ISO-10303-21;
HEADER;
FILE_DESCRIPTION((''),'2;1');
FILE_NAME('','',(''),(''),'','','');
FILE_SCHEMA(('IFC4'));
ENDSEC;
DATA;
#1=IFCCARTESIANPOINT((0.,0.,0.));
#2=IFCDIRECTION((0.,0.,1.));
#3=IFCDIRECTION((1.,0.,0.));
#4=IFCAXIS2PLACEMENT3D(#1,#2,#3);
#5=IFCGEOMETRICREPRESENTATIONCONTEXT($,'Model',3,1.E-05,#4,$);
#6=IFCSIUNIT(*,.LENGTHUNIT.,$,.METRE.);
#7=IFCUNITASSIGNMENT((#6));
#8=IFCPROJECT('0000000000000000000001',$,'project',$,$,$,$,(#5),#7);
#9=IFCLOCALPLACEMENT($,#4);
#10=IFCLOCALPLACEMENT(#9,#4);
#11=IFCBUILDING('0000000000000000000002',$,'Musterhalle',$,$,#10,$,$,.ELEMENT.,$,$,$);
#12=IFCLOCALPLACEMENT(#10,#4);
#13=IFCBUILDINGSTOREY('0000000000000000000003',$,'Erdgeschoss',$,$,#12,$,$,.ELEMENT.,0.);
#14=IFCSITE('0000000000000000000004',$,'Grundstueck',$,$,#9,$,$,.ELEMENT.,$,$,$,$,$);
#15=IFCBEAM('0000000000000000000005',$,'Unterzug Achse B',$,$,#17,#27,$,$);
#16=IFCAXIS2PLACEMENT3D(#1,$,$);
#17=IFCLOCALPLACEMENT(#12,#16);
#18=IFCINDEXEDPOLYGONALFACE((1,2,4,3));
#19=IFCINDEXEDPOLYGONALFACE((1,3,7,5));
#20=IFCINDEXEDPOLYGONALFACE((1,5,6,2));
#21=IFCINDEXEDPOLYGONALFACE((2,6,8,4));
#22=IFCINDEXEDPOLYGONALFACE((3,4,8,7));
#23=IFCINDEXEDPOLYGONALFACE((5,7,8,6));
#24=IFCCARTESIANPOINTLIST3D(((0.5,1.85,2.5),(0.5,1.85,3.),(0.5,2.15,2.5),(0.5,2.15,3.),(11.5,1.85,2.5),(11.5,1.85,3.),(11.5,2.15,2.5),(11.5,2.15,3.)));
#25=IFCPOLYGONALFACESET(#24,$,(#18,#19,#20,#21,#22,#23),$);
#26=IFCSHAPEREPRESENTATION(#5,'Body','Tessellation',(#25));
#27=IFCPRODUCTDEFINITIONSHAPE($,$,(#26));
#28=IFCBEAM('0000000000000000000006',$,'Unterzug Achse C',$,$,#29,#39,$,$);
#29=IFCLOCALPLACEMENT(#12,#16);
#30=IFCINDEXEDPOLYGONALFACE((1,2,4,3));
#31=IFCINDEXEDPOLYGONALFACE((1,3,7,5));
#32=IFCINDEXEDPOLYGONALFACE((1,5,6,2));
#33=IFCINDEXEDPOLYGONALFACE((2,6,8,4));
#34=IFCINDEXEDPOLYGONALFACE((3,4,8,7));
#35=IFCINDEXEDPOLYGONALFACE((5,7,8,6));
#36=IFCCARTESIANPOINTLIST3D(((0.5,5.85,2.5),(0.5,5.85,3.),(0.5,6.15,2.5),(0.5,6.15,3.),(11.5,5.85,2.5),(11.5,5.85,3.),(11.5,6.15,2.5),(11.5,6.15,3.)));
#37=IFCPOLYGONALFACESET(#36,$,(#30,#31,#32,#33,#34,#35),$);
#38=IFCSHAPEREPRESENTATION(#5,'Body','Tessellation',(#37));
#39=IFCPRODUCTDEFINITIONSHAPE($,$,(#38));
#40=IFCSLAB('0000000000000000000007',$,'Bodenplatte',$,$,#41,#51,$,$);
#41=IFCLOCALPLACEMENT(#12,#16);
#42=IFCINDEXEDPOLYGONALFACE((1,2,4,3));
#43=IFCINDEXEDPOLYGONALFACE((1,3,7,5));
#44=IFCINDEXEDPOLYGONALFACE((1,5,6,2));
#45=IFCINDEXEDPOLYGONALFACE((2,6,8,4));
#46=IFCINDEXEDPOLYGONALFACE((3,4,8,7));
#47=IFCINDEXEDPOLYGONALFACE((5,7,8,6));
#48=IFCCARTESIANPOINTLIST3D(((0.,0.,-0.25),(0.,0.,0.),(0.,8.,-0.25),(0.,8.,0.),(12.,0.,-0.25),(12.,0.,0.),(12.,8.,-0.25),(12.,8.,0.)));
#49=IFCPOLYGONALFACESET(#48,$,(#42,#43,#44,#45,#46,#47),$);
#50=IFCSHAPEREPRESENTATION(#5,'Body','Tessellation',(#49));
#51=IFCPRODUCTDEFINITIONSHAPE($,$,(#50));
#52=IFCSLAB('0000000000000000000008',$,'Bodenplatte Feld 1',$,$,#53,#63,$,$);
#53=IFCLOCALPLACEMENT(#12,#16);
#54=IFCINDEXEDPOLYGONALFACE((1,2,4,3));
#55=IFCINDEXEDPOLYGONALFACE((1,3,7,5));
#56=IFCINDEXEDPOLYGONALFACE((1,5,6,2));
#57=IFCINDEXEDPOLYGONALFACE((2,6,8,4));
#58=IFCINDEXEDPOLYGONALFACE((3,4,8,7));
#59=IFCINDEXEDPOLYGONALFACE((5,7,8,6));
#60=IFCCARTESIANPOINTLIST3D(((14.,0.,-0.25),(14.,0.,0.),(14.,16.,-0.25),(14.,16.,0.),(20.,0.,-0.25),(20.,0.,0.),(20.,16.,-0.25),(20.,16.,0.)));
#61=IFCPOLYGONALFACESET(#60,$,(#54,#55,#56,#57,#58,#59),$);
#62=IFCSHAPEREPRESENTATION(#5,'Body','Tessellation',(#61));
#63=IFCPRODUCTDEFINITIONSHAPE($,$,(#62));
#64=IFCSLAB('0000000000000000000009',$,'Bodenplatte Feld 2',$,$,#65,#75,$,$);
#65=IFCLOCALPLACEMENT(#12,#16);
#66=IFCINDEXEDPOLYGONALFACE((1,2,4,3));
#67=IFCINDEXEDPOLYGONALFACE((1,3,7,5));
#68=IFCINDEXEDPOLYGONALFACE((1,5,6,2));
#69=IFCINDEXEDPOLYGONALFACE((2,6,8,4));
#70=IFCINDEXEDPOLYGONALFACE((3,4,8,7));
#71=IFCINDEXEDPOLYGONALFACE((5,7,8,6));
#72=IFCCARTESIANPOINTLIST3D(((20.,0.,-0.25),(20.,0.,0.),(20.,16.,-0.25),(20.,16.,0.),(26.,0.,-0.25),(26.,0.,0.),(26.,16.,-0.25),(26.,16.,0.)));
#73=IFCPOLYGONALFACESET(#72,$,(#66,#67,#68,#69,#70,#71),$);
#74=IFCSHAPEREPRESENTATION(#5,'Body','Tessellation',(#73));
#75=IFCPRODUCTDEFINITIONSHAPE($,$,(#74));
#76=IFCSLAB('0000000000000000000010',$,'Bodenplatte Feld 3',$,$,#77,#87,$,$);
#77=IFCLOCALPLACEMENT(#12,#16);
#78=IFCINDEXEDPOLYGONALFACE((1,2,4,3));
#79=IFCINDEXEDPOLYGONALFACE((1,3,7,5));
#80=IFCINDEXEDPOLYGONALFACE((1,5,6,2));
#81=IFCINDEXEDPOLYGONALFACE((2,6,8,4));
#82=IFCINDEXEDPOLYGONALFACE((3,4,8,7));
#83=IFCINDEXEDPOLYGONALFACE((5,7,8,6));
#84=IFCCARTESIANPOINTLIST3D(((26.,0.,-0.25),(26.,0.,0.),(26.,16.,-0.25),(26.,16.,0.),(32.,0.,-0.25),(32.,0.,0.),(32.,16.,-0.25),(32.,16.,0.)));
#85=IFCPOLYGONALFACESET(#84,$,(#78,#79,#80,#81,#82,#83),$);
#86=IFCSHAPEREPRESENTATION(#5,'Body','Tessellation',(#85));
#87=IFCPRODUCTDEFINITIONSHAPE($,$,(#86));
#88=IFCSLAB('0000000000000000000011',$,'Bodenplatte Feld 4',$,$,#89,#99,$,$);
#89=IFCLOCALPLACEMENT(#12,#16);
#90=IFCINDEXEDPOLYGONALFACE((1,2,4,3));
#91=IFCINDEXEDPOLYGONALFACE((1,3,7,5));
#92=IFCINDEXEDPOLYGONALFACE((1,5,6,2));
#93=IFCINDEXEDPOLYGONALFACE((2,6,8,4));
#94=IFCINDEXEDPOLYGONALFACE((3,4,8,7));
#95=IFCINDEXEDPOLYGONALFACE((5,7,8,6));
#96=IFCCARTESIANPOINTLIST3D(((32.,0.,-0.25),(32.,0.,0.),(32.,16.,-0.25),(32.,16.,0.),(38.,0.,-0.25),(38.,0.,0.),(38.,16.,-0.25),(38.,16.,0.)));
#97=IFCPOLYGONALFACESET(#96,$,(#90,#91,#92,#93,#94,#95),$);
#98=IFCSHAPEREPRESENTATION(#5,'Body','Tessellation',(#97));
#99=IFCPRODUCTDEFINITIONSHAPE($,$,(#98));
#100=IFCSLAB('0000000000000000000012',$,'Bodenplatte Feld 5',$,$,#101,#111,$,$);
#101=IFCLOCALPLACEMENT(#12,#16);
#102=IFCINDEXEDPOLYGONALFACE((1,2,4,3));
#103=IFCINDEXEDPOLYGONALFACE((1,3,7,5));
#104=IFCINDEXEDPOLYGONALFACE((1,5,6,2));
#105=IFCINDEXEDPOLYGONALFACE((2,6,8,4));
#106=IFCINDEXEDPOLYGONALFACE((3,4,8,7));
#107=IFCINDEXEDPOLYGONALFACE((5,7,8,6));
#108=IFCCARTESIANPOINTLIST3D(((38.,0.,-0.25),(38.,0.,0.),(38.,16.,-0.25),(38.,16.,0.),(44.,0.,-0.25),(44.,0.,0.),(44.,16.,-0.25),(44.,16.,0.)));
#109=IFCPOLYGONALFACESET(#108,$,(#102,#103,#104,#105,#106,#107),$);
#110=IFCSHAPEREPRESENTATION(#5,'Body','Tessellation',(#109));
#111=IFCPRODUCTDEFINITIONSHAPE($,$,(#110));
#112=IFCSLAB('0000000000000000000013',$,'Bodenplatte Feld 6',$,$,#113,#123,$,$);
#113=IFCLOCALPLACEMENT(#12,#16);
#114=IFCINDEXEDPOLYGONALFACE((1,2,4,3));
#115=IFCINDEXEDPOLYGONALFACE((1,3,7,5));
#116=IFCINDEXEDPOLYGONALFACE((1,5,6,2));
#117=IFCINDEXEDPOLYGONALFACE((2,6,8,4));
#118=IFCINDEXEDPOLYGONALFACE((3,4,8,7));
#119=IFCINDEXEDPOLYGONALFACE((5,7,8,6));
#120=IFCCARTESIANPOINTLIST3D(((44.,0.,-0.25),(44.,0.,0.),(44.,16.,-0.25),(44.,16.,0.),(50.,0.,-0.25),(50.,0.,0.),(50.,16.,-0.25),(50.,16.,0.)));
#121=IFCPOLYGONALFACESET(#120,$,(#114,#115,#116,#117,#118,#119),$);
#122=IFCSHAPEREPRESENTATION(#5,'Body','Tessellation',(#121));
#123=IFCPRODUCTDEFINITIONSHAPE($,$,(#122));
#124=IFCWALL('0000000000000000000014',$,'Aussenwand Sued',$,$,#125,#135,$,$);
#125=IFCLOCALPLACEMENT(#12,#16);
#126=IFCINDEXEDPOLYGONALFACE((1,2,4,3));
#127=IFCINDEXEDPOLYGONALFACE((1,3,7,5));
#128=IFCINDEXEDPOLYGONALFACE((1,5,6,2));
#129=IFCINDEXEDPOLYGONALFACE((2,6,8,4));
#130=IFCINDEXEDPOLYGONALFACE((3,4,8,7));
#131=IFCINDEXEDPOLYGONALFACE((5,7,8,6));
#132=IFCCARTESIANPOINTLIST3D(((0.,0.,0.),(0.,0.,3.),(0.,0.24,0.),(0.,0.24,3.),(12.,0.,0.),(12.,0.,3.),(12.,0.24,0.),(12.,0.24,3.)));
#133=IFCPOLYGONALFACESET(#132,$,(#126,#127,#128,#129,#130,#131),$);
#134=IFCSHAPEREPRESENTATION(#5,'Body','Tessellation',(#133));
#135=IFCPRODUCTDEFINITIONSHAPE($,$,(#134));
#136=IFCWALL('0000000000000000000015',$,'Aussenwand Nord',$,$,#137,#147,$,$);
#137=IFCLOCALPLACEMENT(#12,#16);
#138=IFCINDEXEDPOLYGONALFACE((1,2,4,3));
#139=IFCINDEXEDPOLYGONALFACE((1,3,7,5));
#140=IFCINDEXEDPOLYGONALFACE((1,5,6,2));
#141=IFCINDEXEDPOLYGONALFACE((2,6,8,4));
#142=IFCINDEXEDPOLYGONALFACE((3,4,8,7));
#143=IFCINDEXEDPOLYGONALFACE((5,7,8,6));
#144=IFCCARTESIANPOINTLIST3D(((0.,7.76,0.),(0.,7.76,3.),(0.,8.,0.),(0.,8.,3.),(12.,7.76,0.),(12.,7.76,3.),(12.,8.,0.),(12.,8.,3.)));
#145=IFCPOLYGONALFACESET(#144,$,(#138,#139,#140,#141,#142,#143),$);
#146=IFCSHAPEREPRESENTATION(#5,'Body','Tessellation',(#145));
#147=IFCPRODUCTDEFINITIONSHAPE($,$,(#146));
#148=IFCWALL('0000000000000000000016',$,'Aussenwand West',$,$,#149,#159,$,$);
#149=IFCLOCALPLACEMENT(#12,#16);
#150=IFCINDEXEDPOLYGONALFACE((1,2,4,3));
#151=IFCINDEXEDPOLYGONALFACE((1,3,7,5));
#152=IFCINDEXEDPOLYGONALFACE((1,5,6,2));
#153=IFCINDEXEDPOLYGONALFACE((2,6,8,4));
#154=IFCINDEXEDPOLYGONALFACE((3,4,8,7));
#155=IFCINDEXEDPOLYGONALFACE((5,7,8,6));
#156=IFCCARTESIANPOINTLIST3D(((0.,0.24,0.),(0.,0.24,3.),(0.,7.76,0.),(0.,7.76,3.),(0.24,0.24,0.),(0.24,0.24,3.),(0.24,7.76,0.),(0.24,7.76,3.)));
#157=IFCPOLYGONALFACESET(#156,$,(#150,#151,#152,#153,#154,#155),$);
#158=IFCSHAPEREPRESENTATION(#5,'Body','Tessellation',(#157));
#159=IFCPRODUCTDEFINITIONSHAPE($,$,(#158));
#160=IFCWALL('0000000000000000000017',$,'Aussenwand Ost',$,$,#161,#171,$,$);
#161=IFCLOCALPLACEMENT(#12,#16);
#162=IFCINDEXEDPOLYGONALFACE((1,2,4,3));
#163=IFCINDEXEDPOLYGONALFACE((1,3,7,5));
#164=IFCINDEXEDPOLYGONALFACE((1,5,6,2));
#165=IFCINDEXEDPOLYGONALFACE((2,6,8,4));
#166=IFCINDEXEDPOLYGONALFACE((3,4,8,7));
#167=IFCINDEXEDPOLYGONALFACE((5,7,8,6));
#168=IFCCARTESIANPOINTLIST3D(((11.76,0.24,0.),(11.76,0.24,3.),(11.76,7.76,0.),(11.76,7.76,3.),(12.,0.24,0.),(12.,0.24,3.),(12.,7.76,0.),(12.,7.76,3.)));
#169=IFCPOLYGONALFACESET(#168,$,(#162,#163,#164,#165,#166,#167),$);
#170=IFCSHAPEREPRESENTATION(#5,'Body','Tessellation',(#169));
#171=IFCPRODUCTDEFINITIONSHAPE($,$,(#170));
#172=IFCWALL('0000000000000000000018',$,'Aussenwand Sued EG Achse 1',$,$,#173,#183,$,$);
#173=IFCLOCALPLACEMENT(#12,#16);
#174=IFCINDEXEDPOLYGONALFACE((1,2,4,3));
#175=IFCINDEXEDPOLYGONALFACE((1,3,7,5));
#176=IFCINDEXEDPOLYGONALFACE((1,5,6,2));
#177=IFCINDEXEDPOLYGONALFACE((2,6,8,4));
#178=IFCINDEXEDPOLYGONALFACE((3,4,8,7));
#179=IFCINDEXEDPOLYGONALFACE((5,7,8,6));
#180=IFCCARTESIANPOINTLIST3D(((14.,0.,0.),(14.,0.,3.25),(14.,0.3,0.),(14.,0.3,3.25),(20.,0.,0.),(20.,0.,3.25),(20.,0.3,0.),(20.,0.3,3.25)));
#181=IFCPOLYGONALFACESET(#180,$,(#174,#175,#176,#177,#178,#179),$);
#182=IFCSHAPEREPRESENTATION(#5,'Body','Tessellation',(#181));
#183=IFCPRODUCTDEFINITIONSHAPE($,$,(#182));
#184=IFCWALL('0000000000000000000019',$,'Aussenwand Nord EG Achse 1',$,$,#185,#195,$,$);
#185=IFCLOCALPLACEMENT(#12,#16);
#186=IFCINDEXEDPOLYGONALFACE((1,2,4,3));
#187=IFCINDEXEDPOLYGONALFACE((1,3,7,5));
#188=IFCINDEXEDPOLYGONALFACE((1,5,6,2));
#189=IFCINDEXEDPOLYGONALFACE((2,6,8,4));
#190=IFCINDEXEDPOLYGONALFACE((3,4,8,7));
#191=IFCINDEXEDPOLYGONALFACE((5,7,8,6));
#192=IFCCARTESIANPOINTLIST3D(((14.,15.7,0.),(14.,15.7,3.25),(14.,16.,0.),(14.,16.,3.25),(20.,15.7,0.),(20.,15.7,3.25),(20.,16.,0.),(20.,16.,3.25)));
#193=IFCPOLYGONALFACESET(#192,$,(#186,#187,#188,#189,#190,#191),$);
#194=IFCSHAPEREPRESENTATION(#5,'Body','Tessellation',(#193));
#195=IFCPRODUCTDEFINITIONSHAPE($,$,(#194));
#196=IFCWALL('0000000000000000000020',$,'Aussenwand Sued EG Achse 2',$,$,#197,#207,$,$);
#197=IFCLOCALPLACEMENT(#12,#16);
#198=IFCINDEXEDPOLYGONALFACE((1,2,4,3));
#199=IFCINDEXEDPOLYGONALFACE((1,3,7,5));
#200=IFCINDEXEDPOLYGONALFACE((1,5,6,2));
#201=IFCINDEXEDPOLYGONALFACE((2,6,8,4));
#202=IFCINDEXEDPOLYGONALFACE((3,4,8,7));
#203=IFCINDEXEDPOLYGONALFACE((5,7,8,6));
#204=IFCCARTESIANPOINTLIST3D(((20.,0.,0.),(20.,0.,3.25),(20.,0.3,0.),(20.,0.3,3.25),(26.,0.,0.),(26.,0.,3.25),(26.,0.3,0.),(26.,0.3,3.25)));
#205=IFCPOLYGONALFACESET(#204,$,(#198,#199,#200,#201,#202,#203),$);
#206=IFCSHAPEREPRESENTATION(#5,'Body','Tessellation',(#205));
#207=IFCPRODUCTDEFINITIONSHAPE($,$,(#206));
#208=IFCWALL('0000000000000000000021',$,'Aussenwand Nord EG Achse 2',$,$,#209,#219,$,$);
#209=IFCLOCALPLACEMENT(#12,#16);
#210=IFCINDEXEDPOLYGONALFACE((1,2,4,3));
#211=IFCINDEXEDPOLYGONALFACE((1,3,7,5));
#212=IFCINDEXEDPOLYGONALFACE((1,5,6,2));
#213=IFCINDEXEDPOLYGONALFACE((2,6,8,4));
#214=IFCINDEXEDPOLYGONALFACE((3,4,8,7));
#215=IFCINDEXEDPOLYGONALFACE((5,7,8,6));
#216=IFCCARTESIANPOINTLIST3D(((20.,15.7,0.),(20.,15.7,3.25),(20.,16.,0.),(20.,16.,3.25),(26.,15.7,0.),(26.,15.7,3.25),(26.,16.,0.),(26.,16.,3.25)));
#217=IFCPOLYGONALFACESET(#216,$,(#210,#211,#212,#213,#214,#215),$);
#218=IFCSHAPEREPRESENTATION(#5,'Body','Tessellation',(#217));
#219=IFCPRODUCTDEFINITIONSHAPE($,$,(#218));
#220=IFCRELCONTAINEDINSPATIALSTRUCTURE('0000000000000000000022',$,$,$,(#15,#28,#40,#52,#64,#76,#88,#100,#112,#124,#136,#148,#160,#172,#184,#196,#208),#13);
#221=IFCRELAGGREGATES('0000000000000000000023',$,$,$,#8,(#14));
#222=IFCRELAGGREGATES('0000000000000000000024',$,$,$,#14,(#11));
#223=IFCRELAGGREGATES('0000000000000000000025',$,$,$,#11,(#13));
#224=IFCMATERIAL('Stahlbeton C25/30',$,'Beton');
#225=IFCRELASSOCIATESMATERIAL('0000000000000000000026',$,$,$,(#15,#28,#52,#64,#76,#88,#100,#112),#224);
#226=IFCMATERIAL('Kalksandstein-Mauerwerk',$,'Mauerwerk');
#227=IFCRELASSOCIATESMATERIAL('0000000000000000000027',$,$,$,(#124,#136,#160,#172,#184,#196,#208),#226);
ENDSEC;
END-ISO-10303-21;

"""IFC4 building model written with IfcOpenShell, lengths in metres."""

from ifc_helpers import new_model, si_unit, frame, origin_with_axes, origin_2d, place, context, project, spatial, rectangle, extrude, material, element, save


model = new_model("IFC4")

# Units and contexts
model_context = context("Model", 3, precision=1e-05, world=origin_with_axes())
ifc_project = project(units=[si_unit("LENGTHUNIT", "METRE")], contexts=[model_context])

# Site, building, storey
site_placement = place(None, origin_with_axes())
site = spatial("IfcSite", under=ifc_project, at=site_placement, Name="Grundstueck", CompositionType="ELEMENT")
building_placement = place(site_placement, origin_with_axes())
building = spatial("IfcBuilding", under=site, at=building_placement, Name="Musterhalle", CompositionType="ELEMENT")
storey_placement = place(building_placement, origin_with_axes())
storey = spatial("IfcBuildingStorey", under=building, at=storey_placement, Name="Erdgeschoss", CompositionType="ELEMENT", Elevation=0.0)

# Beams
ifc_material_1 = material(Name="Stahlbeton C25/30", Category="Beton")
placement = place(storey_placement, origin_with_axes())
element("IfcBeam", 1, at=placement, inside=storey, material=ifc_material_1, Name="Unterzug Achse B", context=model_context, shape_type="SweptSolid", body=[
    extrude(rectangle(XDim=11.0, YDim=0.3, at=origin_2d()), frame((6.0, 2.0, 2.5), z_axis=(0.0, 0.0, 1.0), x_axis=(1.0, 0.0, 0.0)), (0.0, 0.0, 1.0), 0.5),
])
element("IfcBeam", 2, at=placement, inside=storey, material=ifc_material_1, Name="Unterzug Achse C", context=model_context, shape_type="SweptSolid", body=[
    extrude(rectangle(XDim=11.0, YDim=0.3, at=origin_2d()), frame((6.0, 6.0, 2.5), z_axis=(0.0, 0.0, 1.0), x_axis=(1.0, 0.0, 0.0)), (0.0, 0.0, 1.0), 0.5),
])

# Slabs
element("IfcSlab", 3, at=placement, inside=storey, Name="Bodenplatte", context=model_context, shape_type="SweptSolid", body=[
    extrude(rectangle(XDim=12.0, YDim=8.0, at=origin_2d()), frame((6.0, 4.0, -0.25), z_axis=(0.0, 0.0, 1.0), x_axis=(1.0, 0.0, 0.0)), (0.0, 0.0, 1.0), 0.25),
])
element("IfcSlab", 4, at=placement, inside=storey, material=ifc_material_1, Name="Bodenplatte Feld 1", context=model_context, shape_type="SweptSolid", body=[
    extrude(rectangle(XDim=6.0, YDim=16.0, at=origin_2d()), frame((17.0, 8.0, -0.25), z_axis=(0.0, 0.0, 1.0), x_axis=(1.0, 0.0, 0.0)), (0.0, 0.0, 1.0), 0.25),
])
element("IfcSlab", 5, at=placement, inside=storey, material=ifc_material_1, Name="Bodenplatte Feld 2", context=model_context, shape_type="SweptSolid", body=[
    extrude(rectangle(XDim=6.0, YDim=16.0, at=origin_2d()), frame((23.0, 8.0, -0.25), z_axis=(0.0, 0.0, 1.0), x_axis=(1.0, 0.0, 0.0)), (0.0, 0.0, 1.0), 0.25),
])
element("IfcSlab", 6, at=placement, inside=storey, material=ifc_material_1, Name="Bodenplatte Feld 3", context=model_context, shape_type="SweptSolid", body=[
    extrude(rectangle(XDim=6.0, YDim=16.0, at=origin_2d()), frame((29.0, 8.0, -0.25), z_axis=(0.0, 0.0, 1.0), x_axis=(1.0, 0.0, 0.0)), (0.0, 0.0, 1.0), 0.25),
])
element("IfcSlab", 7, at=placement, inside=storey, material=ifc_material_1, Name="Bodenplatte Feld 4", context=model_context, shape_type="SweptSolid", body=[
    extrude(rectangle(XDim=6.0, YDim=16.0, at=origin_2d()), frame((35.0, 8.0, -0.25), z_axis=(0.0, 0.0, 1.0), x_axis=(1.0, 0.0, 0.0)), (0.0, 0.0, 1.0), 0.25),
])
element("IfcSlab", 8, at=placement, inside=storey, material=ifc_material_1, Name="Bodenplatte Feld 5", context=model_context, shape_type="SweptSolid", body=[
    extrude(rectangle(XDim=6.0, YDim=16.0, at=origin_2d()), frame((41.0, 8.0, -0.25), z_axis=(0.0, 0.0, 1.0), x_axis=(1.0, 0.0, 0.0)), (0.0, 0.0, 1.0), 0.25),
])
element("IfcSlab", 9, at=placement, inside=storey, material=ifc_material_1, Name="Bodenplatte Feld 6", context=model_context, shape_type="SweptSolid", body=[
    extrude(rectangle(XDim=6.0, YDim=16.0, at=origin_2d()), frame((47.0, 8.0, -0.25), z_axis=(0.0, 0.0, 1.0), x_axis=(1.0, 0.0, 0.0)), (0.0, 0.0, 1.0), 0.25),
])

# Walls
ifc_material_2 = material(Name="Kalksandstein-Mauerwerk", Category="Mauerwerk")
element("IfcWall", 10, at=placement, inside=storey, material=ifc_material_2, Name="Aussenwand Sued", context=model_context, shape_type="SweptSolid", body=[
    extrude(rectangle(XDim=12.0, YDim=0.24, at=origin_2d()), frame((6.0, 0.12, 0.0), z_axis=(0.0, 0.0, 1.0), x_axis=(1.0, 0.0, 0.0)), (0.0, 0.0, 1.0), 3.0),
])
element("IfcWall", 11, at=placement, inside=storey, material=ifc_material_2, Name="Aussenwand Nord", context=model_context, shape_type="SweptSolid", body=[
    extrude(rectangle(XDim=12.0, YDim=0.24, at=origin_2d()), frame((6.0, 7.88, 0.0), z_axis=(0.0, 0.0, 1.0), x_axis=(1.0, 0.0, 0.0)), (0.0, 0.0, 1.0), 3.0),
])
element("IfcWall", 12, at=placement, inside=storey, Name="Aussenwand West", context=model_context, shape_type="SweptSolid", body=[
    extrude(rectangle(XDim=0.24, YDim=7.52, at=origin_2d()), frame((0.12, 4.0, 0.0), z_axis=(0.0, 0.0, 1.0), x_axis=(1.0, 0.0, 0.0)), (0.0, 0.0, 1.0), 3.0),
])
element("IfcWall", 13, at=placement, inside=storey, material=ifc_material_2, Name="Aussenwand Ost", context=model_context, shape_type="SweptSolid", body=[
    extrude(rectangle(XDim=0.24, YDim=7.52, at=origin_2d()), frame((11.88, 4.0, 0.0), z_axis=(0.0, 0.0, 1.0), x_axis=(1.0, 0.0, 0.0)), (0.0, 0.0, 1.0), 3.0),
])
element("IfcWall", 14, at=placement, inside=storey, material=ifc_material_2, Name="Aussenwand Sued EG Achse 1", context=model_context, shape_type="SweptSolid", body=[
    extrude(rectangle(XDim=6.0, YDim=0.3, at=origin_2d()), frame((17.0, 0.15, 0.0), z_axis=(0.0, 0.0, 1.0), x_axis=(1.0, 0.0, 0.0)), (0.0, 0.0, 1.0), 3.25),
])
element("IfcWall", 15, at=placement, inside=storey, material=ifc_material_2, Name="Aussenwand Nord EG Achse 1", context=model_context, shape_type="SweptSolid", body=[
    extrude(rectangle(XDim=6.0, YDim=0.3, at=origin_2d()), frame((17.0, 15.85, 0.0), z_axis=(0.0, 0.0, 1.0), x_axis=(1.0, 0.0, 0.0)), (0.0, 0.0, 1.0), 3.25),
])
element("IfcWall", 16, at=placement, inside=storey, material=ifc_material_2, Name="Aussenwand Sued EG Achse 2", context=model_context, shape_type="SweptSolid", body=[
    extrude(rectangle(XDim=6.0, YDim=0.3, at=origin_2d()), frame((23.0, 0.15, 0.0), z_axis=(0.0, 0.0, 1.0), x_axis=(1.0, 0.0, 0.0)), (0.0, 0.0, 1.0), 3.25),
])
element("IfcWall", 17, at=placement, inside=storey, material=ifc_material_2, Name="Aussenwand Nord EG Achse 2", context=model_context, shape_type="SweptSolid", body=[
    extrude(rectangle(XDim=6.0, YDim=0.3, at=origin_2d()), frame((23.0, 15.85, 0.0), z_axis=(0.0, 0.0, 1.0), x_axis=(1.0, 0.0, 0.0)), (0.0, 0.0, 1.0), 3.25),
])

save(model, "model.ifc")
